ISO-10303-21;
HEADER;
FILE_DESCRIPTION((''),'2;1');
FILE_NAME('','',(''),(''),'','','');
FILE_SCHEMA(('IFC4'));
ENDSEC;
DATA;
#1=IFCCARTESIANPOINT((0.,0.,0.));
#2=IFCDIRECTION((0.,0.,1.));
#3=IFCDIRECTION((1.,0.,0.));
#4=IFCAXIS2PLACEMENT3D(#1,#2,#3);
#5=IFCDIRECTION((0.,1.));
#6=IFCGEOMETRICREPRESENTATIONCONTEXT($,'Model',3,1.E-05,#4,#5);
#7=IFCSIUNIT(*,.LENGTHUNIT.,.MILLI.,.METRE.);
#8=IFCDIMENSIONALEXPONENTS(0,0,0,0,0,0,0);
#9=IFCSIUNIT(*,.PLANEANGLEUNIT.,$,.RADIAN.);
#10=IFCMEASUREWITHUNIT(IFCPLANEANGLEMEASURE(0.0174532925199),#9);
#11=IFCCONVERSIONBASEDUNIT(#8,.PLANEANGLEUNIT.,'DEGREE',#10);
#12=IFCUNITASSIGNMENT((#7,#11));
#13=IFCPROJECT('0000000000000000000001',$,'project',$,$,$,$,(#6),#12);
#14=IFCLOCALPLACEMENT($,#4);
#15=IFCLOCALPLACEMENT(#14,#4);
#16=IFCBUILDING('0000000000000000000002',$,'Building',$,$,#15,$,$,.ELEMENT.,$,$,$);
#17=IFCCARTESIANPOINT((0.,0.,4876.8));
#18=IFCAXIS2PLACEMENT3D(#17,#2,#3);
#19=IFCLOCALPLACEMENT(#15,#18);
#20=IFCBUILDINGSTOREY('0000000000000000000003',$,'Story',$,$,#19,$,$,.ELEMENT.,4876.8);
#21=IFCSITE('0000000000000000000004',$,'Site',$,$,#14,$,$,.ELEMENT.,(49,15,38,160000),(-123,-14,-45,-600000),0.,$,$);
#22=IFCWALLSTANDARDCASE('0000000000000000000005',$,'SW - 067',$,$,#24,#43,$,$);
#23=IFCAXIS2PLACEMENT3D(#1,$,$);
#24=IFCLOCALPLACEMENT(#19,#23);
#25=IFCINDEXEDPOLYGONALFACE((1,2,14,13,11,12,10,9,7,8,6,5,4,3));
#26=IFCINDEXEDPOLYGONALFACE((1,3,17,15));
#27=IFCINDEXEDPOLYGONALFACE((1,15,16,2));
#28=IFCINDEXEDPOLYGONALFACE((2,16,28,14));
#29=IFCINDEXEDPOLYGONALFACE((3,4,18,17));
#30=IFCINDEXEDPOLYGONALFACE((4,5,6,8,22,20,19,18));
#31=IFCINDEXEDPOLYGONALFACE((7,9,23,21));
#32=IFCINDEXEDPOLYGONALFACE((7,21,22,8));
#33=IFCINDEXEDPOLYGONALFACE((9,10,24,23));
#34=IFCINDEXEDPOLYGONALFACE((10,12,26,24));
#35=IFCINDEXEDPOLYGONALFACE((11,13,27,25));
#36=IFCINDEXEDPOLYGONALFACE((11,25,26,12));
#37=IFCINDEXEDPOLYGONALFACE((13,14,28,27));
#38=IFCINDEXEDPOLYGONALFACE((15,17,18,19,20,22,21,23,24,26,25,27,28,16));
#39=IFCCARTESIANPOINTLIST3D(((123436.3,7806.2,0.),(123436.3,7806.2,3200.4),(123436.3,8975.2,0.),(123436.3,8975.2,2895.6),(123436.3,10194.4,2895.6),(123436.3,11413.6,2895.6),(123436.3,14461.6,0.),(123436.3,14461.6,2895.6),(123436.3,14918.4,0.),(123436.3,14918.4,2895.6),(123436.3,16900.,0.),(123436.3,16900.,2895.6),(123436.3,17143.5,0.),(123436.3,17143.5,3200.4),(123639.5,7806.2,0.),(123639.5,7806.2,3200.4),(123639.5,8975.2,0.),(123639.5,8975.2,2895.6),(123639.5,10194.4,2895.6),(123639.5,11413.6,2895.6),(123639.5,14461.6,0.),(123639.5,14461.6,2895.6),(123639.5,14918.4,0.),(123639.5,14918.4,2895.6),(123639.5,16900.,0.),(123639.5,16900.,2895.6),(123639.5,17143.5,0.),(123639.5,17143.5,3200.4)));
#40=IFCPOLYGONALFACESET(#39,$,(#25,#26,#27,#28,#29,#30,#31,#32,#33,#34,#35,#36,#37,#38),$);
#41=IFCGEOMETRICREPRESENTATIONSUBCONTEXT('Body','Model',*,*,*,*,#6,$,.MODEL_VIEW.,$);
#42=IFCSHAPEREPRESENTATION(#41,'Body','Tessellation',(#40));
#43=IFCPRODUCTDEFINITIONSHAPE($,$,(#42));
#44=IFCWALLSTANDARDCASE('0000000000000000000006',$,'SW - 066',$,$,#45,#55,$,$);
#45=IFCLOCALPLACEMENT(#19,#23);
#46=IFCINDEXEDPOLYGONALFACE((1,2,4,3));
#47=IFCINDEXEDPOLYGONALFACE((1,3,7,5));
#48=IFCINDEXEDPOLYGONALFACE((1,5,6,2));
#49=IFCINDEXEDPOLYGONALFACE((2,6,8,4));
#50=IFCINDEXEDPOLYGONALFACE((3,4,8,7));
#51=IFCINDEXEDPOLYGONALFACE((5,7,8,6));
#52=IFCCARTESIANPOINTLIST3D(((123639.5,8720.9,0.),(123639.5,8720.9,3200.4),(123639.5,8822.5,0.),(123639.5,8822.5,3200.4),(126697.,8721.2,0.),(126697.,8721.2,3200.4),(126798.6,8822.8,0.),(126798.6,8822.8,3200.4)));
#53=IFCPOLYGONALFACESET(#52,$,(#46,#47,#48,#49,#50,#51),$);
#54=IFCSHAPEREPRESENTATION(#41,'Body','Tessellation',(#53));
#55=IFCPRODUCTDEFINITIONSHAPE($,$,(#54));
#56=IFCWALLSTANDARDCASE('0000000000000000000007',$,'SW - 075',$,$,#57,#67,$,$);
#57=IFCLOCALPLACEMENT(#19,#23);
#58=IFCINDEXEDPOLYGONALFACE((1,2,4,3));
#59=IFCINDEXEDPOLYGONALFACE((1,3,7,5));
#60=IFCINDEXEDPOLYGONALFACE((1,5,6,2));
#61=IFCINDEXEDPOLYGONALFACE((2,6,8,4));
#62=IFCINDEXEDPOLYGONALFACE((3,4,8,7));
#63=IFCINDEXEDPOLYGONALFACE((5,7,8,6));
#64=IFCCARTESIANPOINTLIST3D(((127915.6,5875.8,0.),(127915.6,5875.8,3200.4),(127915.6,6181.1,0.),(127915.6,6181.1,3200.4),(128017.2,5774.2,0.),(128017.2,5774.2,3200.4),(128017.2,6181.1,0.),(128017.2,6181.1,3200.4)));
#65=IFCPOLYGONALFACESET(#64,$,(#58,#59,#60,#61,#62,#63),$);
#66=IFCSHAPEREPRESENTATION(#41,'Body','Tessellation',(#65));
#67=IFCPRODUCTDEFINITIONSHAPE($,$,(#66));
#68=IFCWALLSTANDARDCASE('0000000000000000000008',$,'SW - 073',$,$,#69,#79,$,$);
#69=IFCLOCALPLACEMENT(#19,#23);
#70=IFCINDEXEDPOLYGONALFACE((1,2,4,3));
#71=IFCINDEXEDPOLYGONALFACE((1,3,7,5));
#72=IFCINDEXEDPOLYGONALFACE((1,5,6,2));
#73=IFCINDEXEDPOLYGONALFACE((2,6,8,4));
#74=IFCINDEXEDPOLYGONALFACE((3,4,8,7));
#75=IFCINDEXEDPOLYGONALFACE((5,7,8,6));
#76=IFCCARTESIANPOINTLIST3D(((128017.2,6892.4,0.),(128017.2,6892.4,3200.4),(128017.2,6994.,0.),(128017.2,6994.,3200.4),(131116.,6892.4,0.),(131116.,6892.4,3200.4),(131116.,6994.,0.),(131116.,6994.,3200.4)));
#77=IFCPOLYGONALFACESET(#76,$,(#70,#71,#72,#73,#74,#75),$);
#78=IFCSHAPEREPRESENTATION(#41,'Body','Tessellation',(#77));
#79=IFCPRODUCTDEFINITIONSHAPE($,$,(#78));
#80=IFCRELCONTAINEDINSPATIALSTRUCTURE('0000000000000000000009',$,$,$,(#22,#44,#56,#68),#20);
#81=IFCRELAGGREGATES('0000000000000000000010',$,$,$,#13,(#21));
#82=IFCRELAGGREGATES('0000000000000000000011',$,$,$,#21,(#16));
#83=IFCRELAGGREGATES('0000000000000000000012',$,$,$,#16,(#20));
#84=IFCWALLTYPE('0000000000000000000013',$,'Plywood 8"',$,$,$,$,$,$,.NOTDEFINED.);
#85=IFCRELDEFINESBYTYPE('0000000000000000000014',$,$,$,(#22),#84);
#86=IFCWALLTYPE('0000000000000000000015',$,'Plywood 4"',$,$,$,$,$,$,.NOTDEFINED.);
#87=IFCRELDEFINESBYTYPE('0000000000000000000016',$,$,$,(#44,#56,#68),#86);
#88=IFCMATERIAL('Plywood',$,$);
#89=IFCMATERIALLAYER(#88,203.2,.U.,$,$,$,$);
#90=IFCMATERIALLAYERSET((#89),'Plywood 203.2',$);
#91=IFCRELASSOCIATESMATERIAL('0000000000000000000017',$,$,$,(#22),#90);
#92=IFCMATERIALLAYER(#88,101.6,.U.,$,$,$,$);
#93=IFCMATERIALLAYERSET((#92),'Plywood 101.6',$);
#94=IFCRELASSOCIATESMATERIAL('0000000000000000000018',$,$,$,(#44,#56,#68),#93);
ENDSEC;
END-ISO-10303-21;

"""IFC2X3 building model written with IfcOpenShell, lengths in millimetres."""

from ifc_helpers import new_model, entity, si_unit, converted_unit, direction, frame, origin_with_axes, origin_2d_with_axis, place, context, subcontext, project, spatial, polyline, rectangle, outline, extrude, material, layer, layer_set, layer_usage, type_object, element, save


model = new_model("IFC2X3")

# Units and contexts
model_context = context("Model", 3, precision=1e-05, world=origin_with_axes(), true_north=direction((0.0, 1.0)))
body_context = subcontext(model_context, "Body", "Model", "MODEL_VIEW")
ifc_project = project(units=[si_unit("LENGTHUNIT", "METRE", prefix="MILLI"), converted_unit("PLANEANGLEUNIT", "DEGREE", entity("IfcPlaneAngleMeasure", 0.0174532925199), si_unit("PLANEANGLEUNIT", "RADIAN"), dimensions=[0, 0, 0, 0, 0, 0, 0])], contexts=[model_context])

# Site, building, storey
site_placement = place(None, origin_with_axes())
site = spatial("IfcSite", under=ifc_project, at=site_placement, Name="Site", CompositionType="ELEMENT", RefLatitude=(49, 15, 38, 160000), RefLongitude=(-123, -14, -45, -600000), RefElevation=0.0)
building_placement = place(site_placement, origin_with_axes())
building = spatial("IfcBuilding", under=site, at=building_placement, Name="Building", CompositionType="ELEMENT")
storey_placement = place(building_placement, frame((0.0, 0.0, 4876.8), z_axis=(0.0, 0.0, 1.0), x_axis=(1.0, 0.0, 0.0)))
storey = spatial("IfcBuildingStorey", under=building, at=storey_placement, Name="Story", CompositionType="ELEMENT", Elevation=4876.8)

# Shared definitions
ifc_material_1 = material(Name="Plywood")
ifc_layer_1 = layer(ifc_material_1, 203.2, ventilated="UNKNOWN")
ifc_layer_set_1 = layer_set([ifc_layer_1], Name="Plywood 203.2")
wall_type_1 = type_object("IfcWallType", Name="Plywood 8\"", PredefinedType="NOTDEFINED")

# Wall, openings
ifc_layer_usage_1 = layer_usage(ifc_layer_set_1, "AXIS2", "POSITIVE", 0.0)
wall_1_placement = place(storey_placement, frame((123639.5, 7603.0, 0.0), z_axis=(0.0, 0.0, 1.0), x_axis=(0.0, 1.0, 0.0)))
wall_1 = element("IfcWallStandardCase", 1, at=wall_1_placement, inside=storey, type_object=wall_type_1, material=ifc_layer_usage_1, Name="SW - 067", context=body_context, shape_type="SweptSolid", body=[
    extrude(outline(polyline([(203.2, 0.0), (9540.4, 0.0), (9540.4, 203.2), (203.2, 203.2), (203.2, 0.0)])), origin_with_axes(), (0.0, 0.0, 1.0), 3200.4),
])
opening_1_placement = place(wall_1_placement, frame((1981.7, 0.0, 0.0), z_axis=(0.0, 0.0, 1.0), x_axis=(1.0, 0.0, 0.0)))
element("IfcOpeningElement", 2, at=opening_1_placement, cuts=wall_1, context=body_context, shape_type="SweptSolid", body=[
    extrude(rectangle(XDim=1219.2, YDim=2895.6, at=origin_2d_with_axis()), frame((0.0, -203.2, 1447.8), z_axis=(0.0, -1.0, 0.0), x_axis=(-1.0, 0.0, 0.0)), (0.0, 0.0, -1.0), 609.6),
])
opening_2_placement = place(wall_1_placement, frame((3200.9, 0.0, 0.0), z_axis=(0.0, 0.0, 1.0), x_axis=(1.0, 0.0, 0.0)))
element("IfcOpeningElement", 3, at=opening_2_placement, cuts=wall_1, context=body_context, shape_type="SweptSolid", body=[
    extrude(rectangle(XDim=1219.2, YDim=2895.6, at=origin_2d_with_axis()), frame((0.0, -203.2, 1447.8), z_axis=(0.0, -1.0, 0.0), x_axis=(-1.0, 0.0, 0.0)), (0.0, 0.0, -1.0), 609.6),
])
opening_3_placement = place(wall_1_placement, frame((8306.2, 0.0, 0.0), z_axis=(0.0, 0.0, 1.0), x_axis=(1.0, 0.0, 0.0)))
element("IfcOpeningElement", 4, at=opening_3_placement, cuts=wall_1, context=body_context, shape_type="SweptSolid", body=[
    extrude(rectangle(XDim=1981.5, YDim=2895.6, at=origin_2d_with_axis()), frame((0.0, -203.2, 1447.8), z_axis=(0.0, -1.0, 0.0), x_axis=(-1.0, 0.0, 0.0)), (0.0, 0.0, -1.0), 609.6),
])
opening_4_placement = place(wall_1_placement, frame((5334.5, 0.0, 0.0), z_axis=(0.0, 0.0, 1.0), x_axis=(1.0, 0.0, 0.0)))
element("IfcOpeningElement", 5, at=opening_4_placement, cuts=wall_1, context=body_context, shape_type="SweptSolid", body=[
    extrude(rectangle(XDim=3048.0, YDim=2895.6, at=origin_2d_with_axis()), frame((0.0, -203.2, 1447.8), z_axis=(0.0, -1.0, 0.0), x_axis=(-1.0, 0.0, 0.0)), (0.0, 0.0, -1.0), 609.6),
])
ifc_layer_2 = layer(ifc_material_1, 101.6, ventilated="UNKNOWN")
ifc_layer_set_2 = layer_set([ifc_layer_2], Name="Plywood 101.6")
wall_type_2 = type_object("IfcWallType", Name="Plywood 4\"", PredefinedType="NOTDEFINED")

# Walls
ifc_layer_usage_2 = layer_usage(ifc_layer_set_2, "AXIS2", "NEGATIVE", 0.0)
wall_2_placement = place(storey_placement, frame((126697.0, 8721.2, 0.0), z_axis=(0.0, 0.0, 1.0), x_axis=(-1.0, -0.000087, 0.0)))
element("IfcWallStandardCase", 6, at=wall_2_placement, inside=storey, type_object=wall_type_2, material=ifc_layer_usage_2, Name="SW - 066", context=body_context, shape_type="SweptSolid", body=[
    extrude(outline(polyline([(-101.6, -101.6), (3057.6, -101.6), (3057.6, 0.0), (0.0, 0.0), (-101.6, -101.6)])), origin_with_axes(), (0.0, 0.0, 1.0), 3200.4),
])
ifc_layer_usage_3 = layer_usage(ifc_layer_set_2, "AXIS2", "NEGATIVE", 0.0)
wall_3_placement = place(storey_placement, frame((128017.2, 6181.1, 0.0), z_axis=(0.0, 0.0, 1.0), x_axis=(0.0, -1.0, 0.0)))
element("IfcWallStandardCase", 7, at=wall_3_placement, inside=storey, type_object=wall_type_2, material=ifc_layer_usage_3, Name="SW - 075", context=body_context, shape_type="SweptSolid", body=[
    extrude(outline(polyline([(0.0, -101.6), (305.3, -101.6), (406.9, 0.0), (0.0, 0.0), (0.0, -101.6)])), origin_with_axes(), (0.0, 0.0, 1.0), 3200.4),
])
ifc_layer_usage_4 = layer_usage(ifc_layer_set_2, "AXIS2", "NEGATIVE", 0.0)
wall_4_placement = place(storey_placement, frame((128017.2, 6994.0, 0.0), z_axis=(0.0, 0.0, 1.0), x_axis=(1.0, 0.0, 0.0)))
element("IfcWallStandardCase", 8, at=wall_4_placement, inside=storey, type_object=wall_type_2, material=ifc_layer_usage_4, Name="SW - 073", context=body_context, shape_type="SweptSolid", body=[
    extrude(outline(polyline([(0.0, -101.6), (3098.8, -101.6), (3098.8, 0.0), (0.0, 0.0), (0.0, -101.6)])), origin_with_axes(), (0.0, 0.0, 1.0), 3200.4),
])

save(model, "model.ifc")
